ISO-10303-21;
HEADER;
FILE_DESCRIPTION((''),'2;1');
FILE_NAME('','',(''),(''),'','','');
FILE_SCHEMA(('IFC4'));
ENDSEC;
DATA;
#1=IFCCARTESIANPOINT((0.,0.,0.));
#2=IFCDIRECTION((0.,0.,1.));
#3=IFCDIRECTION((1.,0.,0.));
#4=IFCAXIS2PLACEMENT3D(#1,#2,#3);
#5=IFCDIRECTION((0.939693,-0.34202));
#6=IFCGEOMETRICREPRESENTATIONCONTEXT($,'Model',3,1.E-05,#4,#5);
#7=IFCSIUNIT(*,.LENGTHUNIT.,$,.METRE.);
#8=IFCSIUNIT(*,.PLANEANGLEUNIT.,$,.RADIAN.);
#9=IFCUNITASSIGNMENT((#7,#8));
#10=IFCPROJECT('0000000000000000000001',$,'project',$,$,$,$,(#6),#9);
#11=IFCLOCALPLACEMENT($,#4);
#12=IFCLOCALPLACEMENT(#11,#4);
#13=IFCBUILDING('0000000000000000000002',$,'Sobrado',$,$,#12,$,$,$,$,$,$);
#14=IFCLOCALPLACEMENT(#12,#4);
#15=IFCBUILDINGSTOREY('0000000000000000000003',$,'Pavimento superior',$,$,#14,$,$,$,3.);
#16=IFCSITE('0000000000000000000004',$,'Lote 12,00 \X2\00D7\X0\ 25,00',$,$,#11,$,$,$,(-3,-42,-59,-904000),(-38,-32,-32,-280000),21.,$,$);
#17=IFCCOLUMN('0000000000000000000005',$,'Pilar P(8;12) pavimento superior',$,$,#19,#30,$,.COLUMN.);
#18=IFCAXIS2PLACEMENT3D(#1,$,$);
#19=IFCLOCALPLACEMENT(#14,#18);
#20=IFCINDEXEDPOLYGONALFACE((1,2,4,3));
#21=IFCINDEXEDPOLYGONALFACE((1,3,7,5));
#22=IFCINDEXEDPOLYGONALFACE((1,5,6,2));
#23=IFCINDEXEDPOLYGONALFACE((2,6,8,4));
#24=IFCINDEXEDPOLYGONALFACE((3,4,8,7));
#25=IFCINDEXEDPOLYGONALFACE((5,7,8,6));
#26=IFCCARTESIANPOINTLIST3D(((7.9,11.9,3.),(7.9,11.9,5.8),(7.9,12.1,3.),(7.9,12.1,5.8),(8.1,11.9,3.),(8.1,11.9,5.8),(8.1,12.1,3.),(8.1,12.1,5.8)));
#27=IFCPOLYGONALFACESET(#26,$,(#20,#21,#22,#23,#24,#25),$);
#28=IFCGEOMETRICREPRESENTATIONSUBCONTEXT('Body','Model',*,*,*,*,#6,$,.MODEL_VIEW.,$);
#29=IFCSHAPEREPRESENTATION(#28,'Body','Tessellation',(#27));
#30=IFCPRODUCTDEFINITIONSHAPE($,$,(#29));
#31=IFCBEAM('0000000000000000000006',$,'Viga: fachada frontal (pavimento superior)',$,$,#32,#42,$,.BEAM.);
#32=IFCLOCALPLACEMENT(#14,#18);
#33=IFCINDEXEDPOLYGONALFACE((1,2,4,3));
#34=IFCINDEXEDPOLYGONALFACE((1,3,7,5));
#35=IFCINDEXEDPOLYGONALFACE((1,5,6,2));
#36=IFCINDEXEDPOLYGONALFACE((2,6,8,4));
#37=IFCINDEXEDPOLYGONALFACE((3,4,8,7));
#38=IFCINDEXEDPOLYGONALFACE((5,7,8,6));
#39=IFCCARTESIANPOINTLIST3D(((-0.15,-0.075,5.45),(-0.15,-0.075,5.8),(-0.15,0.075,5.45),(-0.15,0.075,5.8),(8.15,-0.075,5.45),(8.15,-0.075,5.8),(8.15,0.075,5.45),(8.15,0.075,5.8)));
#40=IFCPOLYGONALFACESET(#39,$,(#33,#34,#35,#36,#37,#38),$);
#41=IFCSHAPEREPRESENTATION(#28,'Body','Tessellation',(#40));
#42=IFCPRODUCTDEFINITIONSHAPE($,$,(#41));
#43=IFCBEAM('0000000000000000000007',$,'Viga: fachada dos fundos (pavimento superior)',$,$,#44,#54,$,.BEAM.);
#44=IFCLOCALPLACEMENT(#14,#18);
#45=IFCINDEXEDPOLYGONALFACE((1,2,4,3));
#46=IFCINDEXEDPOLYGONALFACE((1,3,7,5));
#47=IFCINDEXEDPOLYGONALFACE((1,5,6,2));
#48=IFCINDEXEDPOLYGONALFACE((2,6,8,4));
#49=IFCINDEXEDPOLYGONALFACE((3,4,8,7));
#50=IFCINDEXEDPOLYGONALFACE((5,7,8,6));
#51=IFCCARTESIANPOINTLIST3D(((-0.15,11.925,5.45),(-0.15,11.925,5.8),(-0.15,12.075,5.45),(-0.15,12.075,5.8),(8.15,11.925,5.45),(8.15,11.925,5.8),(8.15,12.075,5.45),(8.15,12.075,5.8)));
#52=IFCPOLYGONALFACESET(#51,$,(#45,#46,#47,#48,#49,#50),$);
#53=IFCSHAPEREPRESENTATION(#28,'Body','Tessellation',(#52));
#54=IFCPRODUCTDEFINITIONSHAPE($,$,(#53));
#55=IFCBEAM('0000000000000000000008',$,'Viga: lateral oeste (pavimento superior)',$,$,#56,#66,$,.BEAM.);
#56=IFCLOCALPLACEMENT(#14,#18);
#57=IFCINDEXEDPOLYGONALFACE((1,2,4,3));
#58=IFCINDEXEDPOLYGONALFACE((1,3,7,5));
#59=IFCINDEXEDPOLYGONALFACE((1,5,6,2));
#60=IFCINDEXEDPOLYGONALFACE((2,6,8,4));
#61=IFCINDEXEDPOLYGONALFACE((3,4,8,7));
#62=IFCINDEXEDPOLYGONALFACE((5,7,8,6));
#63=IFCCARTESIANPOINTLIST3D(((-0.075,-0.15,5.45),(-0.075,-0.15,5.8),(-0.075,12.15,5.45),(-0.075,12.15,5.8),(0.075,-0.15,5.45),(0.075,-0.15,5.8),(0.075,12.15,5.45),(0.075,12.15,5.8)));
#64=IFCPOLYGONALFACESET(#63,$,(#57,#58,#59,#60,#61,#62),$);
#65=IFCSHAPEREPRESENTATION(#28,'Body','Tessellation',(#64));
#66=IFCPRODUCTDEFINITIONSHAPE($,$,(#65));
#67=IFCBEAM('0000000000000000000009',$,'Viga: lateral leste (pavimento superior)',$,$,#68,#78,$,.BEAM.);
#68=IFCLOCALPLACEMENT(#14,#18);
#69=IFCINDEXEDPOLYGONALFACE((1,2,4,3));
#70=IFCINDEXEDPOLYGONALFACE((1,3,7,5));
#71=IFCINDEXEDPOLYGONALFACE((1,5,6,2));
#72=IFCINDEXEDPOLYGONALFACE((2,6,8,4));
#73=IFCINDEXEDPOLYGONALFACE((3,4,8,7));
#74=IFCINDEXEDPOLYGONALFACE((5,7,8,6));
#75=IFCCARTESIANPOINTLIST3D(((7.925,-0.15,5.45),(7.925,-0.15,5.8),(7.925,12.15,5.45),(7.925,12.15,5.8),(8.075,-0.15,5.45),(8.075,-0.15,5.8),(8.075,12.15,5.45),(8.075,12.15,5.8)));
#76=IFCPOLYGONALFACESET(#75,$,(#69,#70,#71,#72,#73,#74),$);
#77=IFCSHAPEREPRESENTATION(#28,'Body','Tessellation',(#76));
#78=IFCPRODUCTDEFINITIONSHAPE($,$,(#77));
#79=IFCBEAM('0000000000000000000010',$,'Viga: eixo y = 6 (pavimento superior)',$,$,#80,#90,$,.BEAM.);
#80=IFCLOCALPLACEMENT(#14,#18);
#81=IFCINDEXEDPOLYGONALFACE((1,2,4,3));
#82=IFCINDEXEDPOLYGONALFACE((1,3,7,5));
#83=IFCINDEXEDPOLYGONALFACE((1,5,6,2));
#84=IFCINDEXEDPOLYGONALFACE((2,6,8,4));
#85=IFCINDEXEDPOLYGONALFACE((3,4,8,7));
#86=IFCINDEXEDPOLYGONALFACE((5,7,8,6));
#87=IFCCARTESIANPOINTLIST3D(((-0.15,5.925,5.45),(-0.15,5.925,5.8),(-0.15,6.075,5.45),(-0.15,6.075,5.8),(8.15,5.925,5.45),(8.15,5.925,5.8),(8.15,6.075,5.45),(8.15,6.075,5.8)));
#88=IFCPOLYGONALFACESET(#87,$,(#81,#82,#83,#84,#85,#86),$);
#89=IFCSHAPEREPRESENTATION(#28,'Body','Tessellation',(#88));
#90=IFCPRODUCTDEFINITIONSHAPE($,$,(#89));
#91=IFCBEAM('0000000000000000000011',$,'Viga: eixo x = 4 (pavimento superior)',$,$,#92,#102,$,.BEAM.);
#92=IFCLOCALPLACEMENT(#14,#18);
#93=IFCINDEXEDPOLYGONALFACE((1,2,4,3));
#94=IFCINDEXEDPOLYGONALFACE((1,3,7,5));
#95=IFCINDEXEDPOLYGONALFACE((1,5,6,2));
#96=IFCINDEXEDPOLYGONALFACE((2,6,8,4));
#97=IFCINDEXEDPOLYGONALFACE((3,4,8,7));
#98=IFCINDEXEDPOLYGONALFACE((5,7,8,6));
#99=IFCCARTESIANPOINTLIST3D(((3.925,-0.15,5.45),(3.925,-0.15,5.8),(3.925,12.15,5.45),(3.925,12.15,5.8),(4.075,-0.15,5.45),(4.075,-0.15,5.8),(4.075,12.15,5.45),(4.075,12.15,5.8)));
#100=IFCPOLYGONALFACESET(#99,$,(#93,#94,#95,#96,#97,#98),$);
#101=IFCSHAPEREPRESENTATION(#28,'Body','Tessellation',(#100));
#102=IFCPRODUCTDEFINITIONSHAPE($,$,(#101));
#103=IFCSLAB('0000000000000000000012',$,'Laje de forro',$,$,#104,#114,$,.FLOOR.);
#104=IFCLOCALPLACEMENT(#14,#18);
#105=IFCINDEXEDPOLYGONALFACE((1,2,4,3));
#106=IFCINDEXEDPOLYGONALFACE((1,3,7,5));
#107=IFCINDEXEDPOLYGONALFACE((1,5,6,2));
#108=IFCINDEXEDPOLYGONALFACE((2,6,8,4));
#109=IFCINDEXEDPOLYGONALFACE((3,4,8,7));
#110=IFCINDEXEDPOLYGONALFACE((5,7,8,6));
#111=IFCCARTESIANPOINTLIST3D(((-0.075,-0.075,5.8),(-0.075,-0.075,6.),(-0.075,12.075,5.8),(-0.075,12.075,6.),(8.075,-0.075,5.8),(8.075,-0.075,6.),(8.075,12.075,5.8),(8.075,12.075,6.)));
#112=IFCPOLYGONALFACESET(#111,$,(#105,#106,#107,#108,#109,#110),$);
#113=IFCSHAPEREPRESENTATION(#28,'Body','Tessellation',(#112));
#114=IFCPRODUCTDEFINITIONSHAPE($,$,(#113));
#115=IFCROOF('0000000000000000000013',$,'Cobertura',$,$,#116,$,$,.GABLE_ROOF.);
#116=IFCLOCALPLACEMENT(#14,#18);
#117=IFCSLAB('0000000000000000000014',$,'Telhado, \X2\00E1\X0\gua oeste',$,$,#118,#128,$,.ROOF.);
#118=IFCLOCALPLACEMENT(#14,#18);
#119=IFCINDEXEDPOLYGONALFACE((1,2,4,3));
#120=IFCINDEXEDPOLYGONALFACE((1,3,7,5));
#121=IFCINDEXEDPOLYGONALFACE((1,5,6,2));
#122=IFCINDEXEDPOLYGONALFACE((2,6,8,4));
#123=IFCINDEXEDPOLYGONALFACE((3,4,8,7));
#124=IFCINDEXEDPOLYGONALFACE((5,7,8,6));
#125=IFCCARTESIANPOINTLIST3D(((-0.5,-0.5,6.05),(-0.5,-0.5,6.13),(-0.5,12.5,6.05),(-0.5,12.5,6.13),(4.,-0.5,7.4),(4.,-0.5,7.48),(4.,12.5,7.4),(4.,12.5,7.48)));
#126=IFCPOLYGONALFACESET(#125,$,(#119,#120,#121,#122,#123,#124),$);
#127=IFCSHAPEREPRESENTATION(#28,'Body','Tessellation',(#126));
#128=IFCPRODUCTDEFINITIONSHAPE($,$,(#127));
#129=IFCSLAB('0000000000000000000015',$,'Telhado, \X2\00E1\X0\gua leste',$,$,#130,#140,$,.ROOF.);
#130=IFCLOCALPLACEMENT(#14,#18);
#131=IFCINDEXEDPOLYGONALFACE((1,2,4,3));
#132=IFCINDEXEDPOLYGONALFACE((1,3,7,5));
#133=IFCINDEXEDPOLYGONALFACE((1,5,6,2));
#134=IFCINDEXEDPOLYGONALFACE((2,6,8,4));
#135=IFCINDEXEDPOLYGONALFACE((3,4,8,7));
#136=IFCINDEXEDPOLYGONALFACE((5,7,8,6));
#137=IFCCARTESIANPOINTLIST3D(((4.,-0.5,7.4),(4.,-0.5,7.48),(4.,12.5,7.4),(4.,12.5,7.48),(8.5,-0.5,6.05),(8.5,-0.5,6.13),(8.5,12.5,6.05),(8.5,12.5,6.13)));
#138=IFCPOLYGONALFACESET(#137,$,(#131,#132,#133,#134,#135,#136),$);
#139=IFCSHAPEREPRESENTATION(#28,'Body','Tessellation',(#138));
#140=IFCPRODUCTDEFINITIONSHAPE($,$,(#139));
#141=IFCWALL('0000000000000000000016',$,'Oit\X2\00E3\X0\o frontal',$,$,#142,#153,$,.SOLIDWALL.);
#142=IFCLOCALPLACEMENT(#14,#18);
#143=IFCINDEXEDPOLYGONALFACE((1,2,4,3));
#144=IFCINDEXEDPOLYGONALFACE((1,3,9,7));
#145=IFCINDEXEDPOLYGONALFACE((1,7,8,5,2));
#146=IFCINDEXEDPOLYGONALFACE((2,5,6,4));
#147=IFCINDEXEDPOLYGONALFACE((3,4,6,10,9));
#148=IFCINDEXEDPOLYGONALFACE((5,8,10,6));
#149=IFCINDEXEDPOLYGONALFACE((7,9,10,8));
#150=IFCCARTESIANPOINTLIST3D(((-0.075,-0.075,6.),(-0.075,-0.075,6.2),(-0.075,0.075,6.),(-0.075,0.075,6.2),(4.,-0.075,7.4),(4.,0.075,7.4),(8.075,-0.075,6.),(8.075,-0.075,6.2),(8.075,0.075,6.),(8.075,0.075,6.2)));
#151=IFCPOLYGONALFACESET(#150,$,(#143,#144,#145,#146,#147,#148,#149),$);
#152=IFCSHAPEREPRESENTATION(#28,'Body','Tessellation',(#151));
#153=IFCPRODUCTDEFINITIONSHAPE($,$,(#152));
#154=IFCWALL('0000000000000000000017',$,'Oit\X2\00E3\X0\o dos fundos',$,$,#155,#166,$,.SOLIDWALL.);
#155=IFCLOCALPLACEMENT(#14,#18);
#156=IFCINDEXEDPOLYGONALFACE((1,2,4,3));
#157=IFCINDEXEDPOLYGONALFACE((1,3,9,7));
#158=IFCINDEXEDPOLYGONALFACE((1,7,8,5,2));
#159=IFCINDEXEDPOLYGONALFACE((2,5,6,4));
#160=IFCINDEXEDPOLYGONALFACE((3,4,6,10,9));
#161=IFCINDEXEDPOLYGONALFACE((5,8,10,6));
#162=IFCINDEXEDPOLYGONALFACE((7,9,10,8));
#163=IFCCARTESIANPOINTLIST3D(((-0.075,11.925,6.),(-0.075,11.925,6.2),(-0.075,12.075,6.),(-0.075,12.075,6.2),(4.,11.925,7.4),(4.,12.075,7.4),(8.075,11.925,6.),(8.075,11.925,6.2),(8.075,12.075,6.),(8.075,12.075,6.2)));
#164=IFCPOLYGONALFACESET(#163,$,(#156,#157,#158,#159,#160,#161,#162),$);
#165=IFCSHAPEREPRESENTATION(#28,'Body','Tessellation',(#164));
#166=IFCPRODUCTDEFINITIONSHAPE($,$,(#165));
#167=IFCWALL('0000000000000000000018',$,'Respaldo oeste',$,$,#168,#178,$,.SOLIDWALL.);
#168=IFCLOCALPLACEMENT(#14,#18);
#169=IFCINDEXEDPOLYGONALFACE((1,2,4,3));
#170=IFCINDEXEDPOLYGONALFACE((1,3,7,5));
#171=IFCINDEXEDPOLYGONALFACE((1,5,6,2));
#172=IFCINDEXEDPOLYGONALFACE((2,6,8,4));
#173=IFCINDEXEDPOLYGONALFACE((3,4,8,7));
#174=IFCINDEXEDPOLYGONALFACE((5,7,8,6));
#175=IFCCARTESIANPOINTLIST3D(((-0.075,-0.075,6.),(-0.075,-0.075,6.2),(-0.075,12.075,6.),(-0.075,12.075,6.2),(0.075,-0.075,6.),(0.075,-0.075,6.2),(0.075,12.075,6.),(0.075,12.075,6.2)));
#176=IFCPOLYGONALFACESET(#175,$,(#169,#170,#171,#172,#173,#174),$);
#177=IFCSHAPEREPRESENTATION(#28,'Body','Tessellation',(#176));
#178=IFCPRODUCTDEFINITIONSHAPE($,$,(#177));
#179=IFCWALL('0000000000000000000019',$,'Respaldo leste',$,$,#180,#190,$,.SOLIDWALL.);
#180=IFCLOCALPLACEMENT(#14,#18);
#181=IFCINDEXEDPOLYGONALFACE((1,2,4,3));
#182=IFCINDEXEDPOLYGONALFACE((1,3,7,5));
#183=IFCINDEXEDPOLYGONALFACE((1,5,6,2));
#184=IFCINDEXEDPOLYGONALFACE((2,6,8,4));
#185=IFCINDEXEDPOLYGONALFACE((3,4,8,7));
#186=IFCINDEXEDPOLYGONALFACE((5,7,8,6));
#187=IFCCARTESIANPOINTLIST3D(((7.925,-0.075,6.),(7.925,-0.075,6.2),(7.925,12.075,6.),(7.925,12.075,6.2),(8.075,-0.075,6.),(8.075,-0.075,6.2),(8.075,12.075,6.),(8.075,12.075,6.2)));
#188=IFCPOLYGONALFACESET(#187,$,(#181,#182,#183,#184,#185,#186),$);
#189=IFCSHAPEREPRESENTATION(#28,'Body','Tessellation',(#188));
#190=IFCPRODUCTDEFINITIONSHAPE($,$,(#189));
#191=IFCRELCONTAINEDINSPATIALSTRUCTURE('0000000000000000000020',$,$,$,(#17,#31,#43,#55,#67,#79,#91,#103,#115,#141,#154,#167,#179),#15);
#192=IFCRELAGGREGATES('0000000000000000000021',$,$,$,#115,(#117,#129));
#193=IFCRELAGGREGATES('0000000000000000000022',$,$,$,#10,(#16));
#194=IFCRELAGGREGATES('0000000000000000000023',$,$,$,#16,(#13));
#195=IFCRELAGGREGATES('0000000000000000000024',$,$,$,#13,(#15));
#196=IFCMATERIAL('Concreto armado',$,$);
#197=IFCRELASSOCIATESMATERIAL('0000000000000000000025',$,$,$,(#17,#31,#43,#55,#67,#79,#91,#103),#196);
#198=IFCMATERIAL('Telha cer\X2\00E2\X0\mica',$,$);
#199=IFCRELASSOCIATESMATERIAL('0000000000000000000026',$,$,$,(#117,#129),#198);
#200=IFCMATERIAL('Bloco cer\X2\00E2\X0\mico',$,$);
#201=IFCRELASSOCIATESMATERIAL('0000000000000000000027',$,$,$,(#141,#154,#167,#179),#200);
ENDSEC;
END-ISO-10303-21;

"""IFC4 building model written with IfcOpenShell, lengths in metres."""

from ifc_helpers import new_model, si_unit, direction, frame, origin_with_axes, place, context, subcontext, project, spatial, line, indexed_curve, outline, extrude, material, element, aggregate, save


model = new_model("IFC4")

# Units and contexts
model_context = context("Model", 3, precision=1e-05, world=origin_with_axes(), true_north=direction((0.939693, -0.34202)))
body_context = subcontext(model_context, "Body", "Model", "MODEL_VIEW")
ifc_project = project(units=[si_unit("LENGTHUNIT", "METRE"), si_unit("PLANEANGLEUNIT", "RADIAN")], contexts=[model_context])

# Site, building, storey
site_placement = place(None, origin_with_axes())
site = spatial("IfcSite", under=ifc_project, at=site_placement, Name="Lote 12,00 × 25,00", RefLatitude=(-3, -42, -59, -904000), RefLongitude=(-38, -32, -32, -280000), RefElevation=21.0)
building_placement = place(site_placement, origin_with_axes())
building = spatial("IfcBuilding", under=site, at=building_placement, Name="Sobrado")
storey_placement = place(building_placement, origin_with_axes())
storey = spatial("IfcBuildingStorey", under=building, at=storey_placement, Name="Pavimento superior", Elevation=3.0)

# Column
ifc_material_1 = material(Name="Concreto armado")
column_placement = place(storey_placement, origin_with_axes())
element("IfcColumn", 1, at=column_placement, inside=storey, material=ifc_material_1, Name="Pilar P(8;12) pavimento superior", PredefinedType="COLUMN", context=body_context, shape_type="SweptSolid", body=[
    extrude(outline(indexed_curve([(7.9, 11.9), (8.1, 11.9), (8.1, 12.1), (7.9, 12.1)], segments=[line(1, 2, 3, 4, 1)])), frame((0.0, 0.0, 3.0), z_axis=(0.0, 0.0, 1.0), x_axis=(1.0, 0.0, 0.0)), (0.0, 0.0, 1.0), 2.8),
])

# Beams
beam_1_placement = place(storey_placement, origin_with_axes())
element("IfcBeam", 2, at=beam_1_placement, inside=storey, material=ifc_material_1, Name="Viga: fachada frontal (pavimento superior)", PredefinedType="BEAM", context=body_context, shape_type="SweptSolid", body=[
    extrude(outline(indexed_curve([(-0.15, -0.075), (8.15, -0.075), (8.15, 0.075), (-0.15, 0.075)], segments=[line(1, 2, 3, 4, 1)])), frame((0.0, 0.0, 5.45), z_axis=(0.0, 0.0, 1.0), x_axis=(1.0, 0.0, 0.0)), (0.0, 0.0, 1.0), 0.35),
])
beam_2_placement = place(storey_placement, origin_with_axes())
element("IfcBeam", 3, at=beam_2_placement, inside=storey, material=ifc_material_1, Name="Viga: fachada dos fundos (pavimento superior)", PredefinedType="BEAM", context=body_context, shape_type="SweptSolid", body=[
    extrude(outline(indexed_curve([(-0.15, 11.925), (8.15, 11.925), (8.15, 12.075), (-0.15, 12.075)], segments=[line(1, 2, 3, 4, 1)])), frame((0.0, 0.0, 5.45), z_axis=(0.0, 0.0, 1.0), x_axis=(1.0, 0.0, 0.0)), (0.0, 0.0, 1.0), 0.35),
])
beam_3_placement = place(storey_placement, origin_with_axes())
element("IfcBeam", 4, at=beam_3_placement, inside=storey, material=ifc_material_1, Name="Viga: lateral oeste (pavimento superior)", PredefinedType="BEAM", context=body_context, shape_type="SweptSolid", body=[
    extrude(outline(indexed_curve([(-0.075, -0.15), (0.075, -0.15), (0.075, 12.15), (-0.075, 12.15)], segments=[line(1, 2, 3, 4, 1)])), frame((0.0, 0.0, 5.45), z_axis=(0.0, 0.0, 1.0), x_axis=(1.0, 0.0, 0.0)), (0.0, 0.0, 1.0), 0.35),
])
beam_4_placement = place(storey_placement, origin_with_axes())
element("IfcBeam", 5, at=beam_4_placement, inside=storey, material=ifc_material_1, Name="Viga: lateral leste (pavimento superior)", PredefinedType="BEAM", context=body_context, shape_type="SweptSolid", body=[
    extrude(outline(indexed_curve([(7.925, -0.15), (8.075, -0.15), (8.075, 12.15), (7.925, 12.15)], segments=[line(1, 2, 3, 4, 1)])), frame((0.0, 0.0, 5.45), z_axis=(0.0, 0.0, 1.0), x_axis=(1.0, 0.0, 0.0)), (0.0, 0.0, 1.0), 0.35),
])
beam_5_placement = place(storey_placement, origin_with_axes())
element("IfcBeam", 6, at=beam_5_placement, inside=storey, material=ifc_material_1, Name="Viga: eixo y = 6 (pavimento superior)", PredefinedType="BEAM", context=body_context, shape_type="SweptSolid", body=[
    extrude(outline(indexed_curve([(-0.15, 5.925), (8.15, 5.925), (8.15, 6.075), (-0.15, 6.075)], segments=[line(1, 2, 3, 4, 1)])), frame((0.0, 0.0, 5.45), z_axis=(0.0, 0.0, 1.0), x_axis=(1.0, 0.0, 0.0)), (0.0, 0.0, 1.0), 0.35),
])
beam_6_placement = place(storey_placement, origin_with_axes())
element("IfcBeam", 7, at=beam_6_placement, inside=storey, material=ifc_material_1, Name="Viga: eixo x = 4 (pavimento superior)", PredefinedType="BEAM", context=body_context, shape_type="SweptSolid", body=[
    extrude(outline(indexed_curve([(3.925, -0.15), (4.075, -0.15), (4.075, 12.15), (3.925, 12.15)], segments=[line(1, 2, 3, 4, 1)])), frame((0.0, 0.0, 5.45), z_axis=(0.0, 0.0, 1.0), x_axis=(1.0, 0.0, 0.0)), (0.0, 0.0, 1.0), 0.35),
])

# Slab
slab_1_placement = place(storey_placement, origin_with_axes())
element("IfcSlab", 8, at=slab_1_placement, inside=storey, material=ifc_material_1, Name="Laje de forro", PredefinedType="FLOOR", context=body_context, shape_type="SweptSolid", body=[
    extrude(outline(indexed_curve([(-0.075, -0.075), (8.075, -0.075), (8.075, 12.075), (-0.075, 12.075)], segments=[line(1, 2, 3, 4, 1)])), frame((0.0, 0.0, 5.8), z_axis=(0.0, 0.0, 1.0), x_axis=(1.0, 0.0, 0.0)), (0.0, 0.0, 1.0), 0.2),
])

# Roof, slabs
roof_placement = place(storey_placement, origin_with_axes())
roof = element("IfcRoof", 9, at=roof_placement, inside=storey, Name="Cobertura", PredefinedType="GABLE_ROOF")
ifc_material_2 = material(Name="Telha cerâmica")
slab_2_placement = place(roof_placement, origin_with_axes())
slab_2 = element("IfcSlab", 10, at=slab_2_placement, material=ifc_material_2, Name="Telhado, água oeste", PredefinedType="ROOF", context=body_context, shape_type="SweptSolid", body=[
    extrude(outline(indexed_curve([(-0.5, 6.05), (4.0, 7.4), (4.0, 7.48), (-0.5, 6.13)], segments=[line(1, 2, 3, 4, 1)])), frame((0.0, 12.5, 0.0), z_axis=(0.0, -1.0, 0.0), x_axis=(1.0, 0.0, 0.0)), (0.0, 0.0, 1.0), 13.0),
])
slab_3_placement = place(roof_placement, origin_with_axes())
slab_3 = element("IfcSlab", 11, at=slab_3_placement, material=ifc_material_2, Name="Telhado, água leste", PredefinedType="ROOF", context=body_context, shape_type="SweptSolid", body=[
    extrude(outline(indexed_curve([(4.0, 7.4), (8.5, 6.05), (8.5, 6.13), (4.0, 7.48)], segments=[line(1, 2, 3, 4, 1)])), frame((0.0, 12.5, 0.0), z_axis=(0.0, -1.0, 0.0), x_axis=(1.0, 0.0, 0.0)), (0.0, 0.0, 1.0), 13.0),
])
aggregate(roof, [slab_2, slab_3])

# Walls
ifc_material_3 = material(Name="Bloco cerâmico")
wall_1_placement = place(storey_placement, origin_with_axes())
element("IfcWall", 12, at=wall_1_placement, inside=storey, material=ifc_material_3, Name="Oitão frontal", PredefinedType="SOLIDWALL", context=body_context, shape_type="SweptSolid", body=[
    extrude(outline(indexed_curve([(-0.075, 6.0), (8.075, 6.0), (8.075, 6.2), (4.0, 7.4), (-0.075, 6.2)], segments=[line(1, 2, 3, 4, 5, 1)])), frame((0.0, 0.075, 0.0), z_axis=(0.0, -1.0, 0.0), x_axis=(1.0, 0.0, 0.0)), (0.0, 0.0, 1.0), 0.15),
])
wall_2_placement = place(storey_placement, origin_with_axes())
element("IfcWall", 13, at=wall_2_placement, inside=storey, material=ifc_material_3, Name="Oitão dos fundos", PredefinedType="SOLIDWALL", context=body_context, shape_type="SweptSolid", body=[
    extrude(outline(indexed_curve([(-0.075, 6.0), (8.075, 6.0), (8.075, 6.2), (4.0, 7.4), (-0.075, 6.2)], segments=[line(1, 2, 3, 4, 5, 1)])), frame((0.0, 12.075, 0.0), z_axis=(0.0, -1.0, 0.0), x_axis=(1.0, 0.0, 0.0)), (0.0, 0.0, 1.0), 0.15),
])
wall_3_placement = place(storey_placement, origin_with_axes())
element("IfcWall", 14, at=wall_3_placement, inside=storey, material=ifc_material_3, Name="Respaldo oeste", PredefinedType="SOLIDWALL", context=body_context, shape_type="SweptSolid", body=[
    extrude(outline(indexed_curve([(-0.075, -0.075), (0.075, -0.075), (0.075, 12.075), (-0.075, 12.075)], segments=[line(1, 2, 3, 4, 1)])), frame((0.0, 0.0, 6.0), z_axis=(0.0, 0.0, 1.0), x_axis=(1.0, 0.0, 0.0)), (0.0, 0.0, 1.0), 0.2),
])
wall_4_placement = place(storey_placement, origin_with_axes())
element("IfcWall", 15, at=wall_4_placement, inside=storey, material=ifc_material_3, Name="Respaldo leste", PredefinedType="SOLIDWALL", context=body_context, shape_type="SweptSolid", body=[
    extrude(outline(indexed_curve([(7.925, -0.075), (8.075, -0.075), (8.075, 12.075), (7.925, 12.075)], segments=[line(1, 2, 3, 4, 1)])), frame((0.0, 0.0, 6.0), z_axis=(0.0, 0.0, 1.0), x_axis=(1.0, 0.0, 0.0)), (0.0, 0.0, 1.0), 0.2),
])

save(model, "model.ifc")
